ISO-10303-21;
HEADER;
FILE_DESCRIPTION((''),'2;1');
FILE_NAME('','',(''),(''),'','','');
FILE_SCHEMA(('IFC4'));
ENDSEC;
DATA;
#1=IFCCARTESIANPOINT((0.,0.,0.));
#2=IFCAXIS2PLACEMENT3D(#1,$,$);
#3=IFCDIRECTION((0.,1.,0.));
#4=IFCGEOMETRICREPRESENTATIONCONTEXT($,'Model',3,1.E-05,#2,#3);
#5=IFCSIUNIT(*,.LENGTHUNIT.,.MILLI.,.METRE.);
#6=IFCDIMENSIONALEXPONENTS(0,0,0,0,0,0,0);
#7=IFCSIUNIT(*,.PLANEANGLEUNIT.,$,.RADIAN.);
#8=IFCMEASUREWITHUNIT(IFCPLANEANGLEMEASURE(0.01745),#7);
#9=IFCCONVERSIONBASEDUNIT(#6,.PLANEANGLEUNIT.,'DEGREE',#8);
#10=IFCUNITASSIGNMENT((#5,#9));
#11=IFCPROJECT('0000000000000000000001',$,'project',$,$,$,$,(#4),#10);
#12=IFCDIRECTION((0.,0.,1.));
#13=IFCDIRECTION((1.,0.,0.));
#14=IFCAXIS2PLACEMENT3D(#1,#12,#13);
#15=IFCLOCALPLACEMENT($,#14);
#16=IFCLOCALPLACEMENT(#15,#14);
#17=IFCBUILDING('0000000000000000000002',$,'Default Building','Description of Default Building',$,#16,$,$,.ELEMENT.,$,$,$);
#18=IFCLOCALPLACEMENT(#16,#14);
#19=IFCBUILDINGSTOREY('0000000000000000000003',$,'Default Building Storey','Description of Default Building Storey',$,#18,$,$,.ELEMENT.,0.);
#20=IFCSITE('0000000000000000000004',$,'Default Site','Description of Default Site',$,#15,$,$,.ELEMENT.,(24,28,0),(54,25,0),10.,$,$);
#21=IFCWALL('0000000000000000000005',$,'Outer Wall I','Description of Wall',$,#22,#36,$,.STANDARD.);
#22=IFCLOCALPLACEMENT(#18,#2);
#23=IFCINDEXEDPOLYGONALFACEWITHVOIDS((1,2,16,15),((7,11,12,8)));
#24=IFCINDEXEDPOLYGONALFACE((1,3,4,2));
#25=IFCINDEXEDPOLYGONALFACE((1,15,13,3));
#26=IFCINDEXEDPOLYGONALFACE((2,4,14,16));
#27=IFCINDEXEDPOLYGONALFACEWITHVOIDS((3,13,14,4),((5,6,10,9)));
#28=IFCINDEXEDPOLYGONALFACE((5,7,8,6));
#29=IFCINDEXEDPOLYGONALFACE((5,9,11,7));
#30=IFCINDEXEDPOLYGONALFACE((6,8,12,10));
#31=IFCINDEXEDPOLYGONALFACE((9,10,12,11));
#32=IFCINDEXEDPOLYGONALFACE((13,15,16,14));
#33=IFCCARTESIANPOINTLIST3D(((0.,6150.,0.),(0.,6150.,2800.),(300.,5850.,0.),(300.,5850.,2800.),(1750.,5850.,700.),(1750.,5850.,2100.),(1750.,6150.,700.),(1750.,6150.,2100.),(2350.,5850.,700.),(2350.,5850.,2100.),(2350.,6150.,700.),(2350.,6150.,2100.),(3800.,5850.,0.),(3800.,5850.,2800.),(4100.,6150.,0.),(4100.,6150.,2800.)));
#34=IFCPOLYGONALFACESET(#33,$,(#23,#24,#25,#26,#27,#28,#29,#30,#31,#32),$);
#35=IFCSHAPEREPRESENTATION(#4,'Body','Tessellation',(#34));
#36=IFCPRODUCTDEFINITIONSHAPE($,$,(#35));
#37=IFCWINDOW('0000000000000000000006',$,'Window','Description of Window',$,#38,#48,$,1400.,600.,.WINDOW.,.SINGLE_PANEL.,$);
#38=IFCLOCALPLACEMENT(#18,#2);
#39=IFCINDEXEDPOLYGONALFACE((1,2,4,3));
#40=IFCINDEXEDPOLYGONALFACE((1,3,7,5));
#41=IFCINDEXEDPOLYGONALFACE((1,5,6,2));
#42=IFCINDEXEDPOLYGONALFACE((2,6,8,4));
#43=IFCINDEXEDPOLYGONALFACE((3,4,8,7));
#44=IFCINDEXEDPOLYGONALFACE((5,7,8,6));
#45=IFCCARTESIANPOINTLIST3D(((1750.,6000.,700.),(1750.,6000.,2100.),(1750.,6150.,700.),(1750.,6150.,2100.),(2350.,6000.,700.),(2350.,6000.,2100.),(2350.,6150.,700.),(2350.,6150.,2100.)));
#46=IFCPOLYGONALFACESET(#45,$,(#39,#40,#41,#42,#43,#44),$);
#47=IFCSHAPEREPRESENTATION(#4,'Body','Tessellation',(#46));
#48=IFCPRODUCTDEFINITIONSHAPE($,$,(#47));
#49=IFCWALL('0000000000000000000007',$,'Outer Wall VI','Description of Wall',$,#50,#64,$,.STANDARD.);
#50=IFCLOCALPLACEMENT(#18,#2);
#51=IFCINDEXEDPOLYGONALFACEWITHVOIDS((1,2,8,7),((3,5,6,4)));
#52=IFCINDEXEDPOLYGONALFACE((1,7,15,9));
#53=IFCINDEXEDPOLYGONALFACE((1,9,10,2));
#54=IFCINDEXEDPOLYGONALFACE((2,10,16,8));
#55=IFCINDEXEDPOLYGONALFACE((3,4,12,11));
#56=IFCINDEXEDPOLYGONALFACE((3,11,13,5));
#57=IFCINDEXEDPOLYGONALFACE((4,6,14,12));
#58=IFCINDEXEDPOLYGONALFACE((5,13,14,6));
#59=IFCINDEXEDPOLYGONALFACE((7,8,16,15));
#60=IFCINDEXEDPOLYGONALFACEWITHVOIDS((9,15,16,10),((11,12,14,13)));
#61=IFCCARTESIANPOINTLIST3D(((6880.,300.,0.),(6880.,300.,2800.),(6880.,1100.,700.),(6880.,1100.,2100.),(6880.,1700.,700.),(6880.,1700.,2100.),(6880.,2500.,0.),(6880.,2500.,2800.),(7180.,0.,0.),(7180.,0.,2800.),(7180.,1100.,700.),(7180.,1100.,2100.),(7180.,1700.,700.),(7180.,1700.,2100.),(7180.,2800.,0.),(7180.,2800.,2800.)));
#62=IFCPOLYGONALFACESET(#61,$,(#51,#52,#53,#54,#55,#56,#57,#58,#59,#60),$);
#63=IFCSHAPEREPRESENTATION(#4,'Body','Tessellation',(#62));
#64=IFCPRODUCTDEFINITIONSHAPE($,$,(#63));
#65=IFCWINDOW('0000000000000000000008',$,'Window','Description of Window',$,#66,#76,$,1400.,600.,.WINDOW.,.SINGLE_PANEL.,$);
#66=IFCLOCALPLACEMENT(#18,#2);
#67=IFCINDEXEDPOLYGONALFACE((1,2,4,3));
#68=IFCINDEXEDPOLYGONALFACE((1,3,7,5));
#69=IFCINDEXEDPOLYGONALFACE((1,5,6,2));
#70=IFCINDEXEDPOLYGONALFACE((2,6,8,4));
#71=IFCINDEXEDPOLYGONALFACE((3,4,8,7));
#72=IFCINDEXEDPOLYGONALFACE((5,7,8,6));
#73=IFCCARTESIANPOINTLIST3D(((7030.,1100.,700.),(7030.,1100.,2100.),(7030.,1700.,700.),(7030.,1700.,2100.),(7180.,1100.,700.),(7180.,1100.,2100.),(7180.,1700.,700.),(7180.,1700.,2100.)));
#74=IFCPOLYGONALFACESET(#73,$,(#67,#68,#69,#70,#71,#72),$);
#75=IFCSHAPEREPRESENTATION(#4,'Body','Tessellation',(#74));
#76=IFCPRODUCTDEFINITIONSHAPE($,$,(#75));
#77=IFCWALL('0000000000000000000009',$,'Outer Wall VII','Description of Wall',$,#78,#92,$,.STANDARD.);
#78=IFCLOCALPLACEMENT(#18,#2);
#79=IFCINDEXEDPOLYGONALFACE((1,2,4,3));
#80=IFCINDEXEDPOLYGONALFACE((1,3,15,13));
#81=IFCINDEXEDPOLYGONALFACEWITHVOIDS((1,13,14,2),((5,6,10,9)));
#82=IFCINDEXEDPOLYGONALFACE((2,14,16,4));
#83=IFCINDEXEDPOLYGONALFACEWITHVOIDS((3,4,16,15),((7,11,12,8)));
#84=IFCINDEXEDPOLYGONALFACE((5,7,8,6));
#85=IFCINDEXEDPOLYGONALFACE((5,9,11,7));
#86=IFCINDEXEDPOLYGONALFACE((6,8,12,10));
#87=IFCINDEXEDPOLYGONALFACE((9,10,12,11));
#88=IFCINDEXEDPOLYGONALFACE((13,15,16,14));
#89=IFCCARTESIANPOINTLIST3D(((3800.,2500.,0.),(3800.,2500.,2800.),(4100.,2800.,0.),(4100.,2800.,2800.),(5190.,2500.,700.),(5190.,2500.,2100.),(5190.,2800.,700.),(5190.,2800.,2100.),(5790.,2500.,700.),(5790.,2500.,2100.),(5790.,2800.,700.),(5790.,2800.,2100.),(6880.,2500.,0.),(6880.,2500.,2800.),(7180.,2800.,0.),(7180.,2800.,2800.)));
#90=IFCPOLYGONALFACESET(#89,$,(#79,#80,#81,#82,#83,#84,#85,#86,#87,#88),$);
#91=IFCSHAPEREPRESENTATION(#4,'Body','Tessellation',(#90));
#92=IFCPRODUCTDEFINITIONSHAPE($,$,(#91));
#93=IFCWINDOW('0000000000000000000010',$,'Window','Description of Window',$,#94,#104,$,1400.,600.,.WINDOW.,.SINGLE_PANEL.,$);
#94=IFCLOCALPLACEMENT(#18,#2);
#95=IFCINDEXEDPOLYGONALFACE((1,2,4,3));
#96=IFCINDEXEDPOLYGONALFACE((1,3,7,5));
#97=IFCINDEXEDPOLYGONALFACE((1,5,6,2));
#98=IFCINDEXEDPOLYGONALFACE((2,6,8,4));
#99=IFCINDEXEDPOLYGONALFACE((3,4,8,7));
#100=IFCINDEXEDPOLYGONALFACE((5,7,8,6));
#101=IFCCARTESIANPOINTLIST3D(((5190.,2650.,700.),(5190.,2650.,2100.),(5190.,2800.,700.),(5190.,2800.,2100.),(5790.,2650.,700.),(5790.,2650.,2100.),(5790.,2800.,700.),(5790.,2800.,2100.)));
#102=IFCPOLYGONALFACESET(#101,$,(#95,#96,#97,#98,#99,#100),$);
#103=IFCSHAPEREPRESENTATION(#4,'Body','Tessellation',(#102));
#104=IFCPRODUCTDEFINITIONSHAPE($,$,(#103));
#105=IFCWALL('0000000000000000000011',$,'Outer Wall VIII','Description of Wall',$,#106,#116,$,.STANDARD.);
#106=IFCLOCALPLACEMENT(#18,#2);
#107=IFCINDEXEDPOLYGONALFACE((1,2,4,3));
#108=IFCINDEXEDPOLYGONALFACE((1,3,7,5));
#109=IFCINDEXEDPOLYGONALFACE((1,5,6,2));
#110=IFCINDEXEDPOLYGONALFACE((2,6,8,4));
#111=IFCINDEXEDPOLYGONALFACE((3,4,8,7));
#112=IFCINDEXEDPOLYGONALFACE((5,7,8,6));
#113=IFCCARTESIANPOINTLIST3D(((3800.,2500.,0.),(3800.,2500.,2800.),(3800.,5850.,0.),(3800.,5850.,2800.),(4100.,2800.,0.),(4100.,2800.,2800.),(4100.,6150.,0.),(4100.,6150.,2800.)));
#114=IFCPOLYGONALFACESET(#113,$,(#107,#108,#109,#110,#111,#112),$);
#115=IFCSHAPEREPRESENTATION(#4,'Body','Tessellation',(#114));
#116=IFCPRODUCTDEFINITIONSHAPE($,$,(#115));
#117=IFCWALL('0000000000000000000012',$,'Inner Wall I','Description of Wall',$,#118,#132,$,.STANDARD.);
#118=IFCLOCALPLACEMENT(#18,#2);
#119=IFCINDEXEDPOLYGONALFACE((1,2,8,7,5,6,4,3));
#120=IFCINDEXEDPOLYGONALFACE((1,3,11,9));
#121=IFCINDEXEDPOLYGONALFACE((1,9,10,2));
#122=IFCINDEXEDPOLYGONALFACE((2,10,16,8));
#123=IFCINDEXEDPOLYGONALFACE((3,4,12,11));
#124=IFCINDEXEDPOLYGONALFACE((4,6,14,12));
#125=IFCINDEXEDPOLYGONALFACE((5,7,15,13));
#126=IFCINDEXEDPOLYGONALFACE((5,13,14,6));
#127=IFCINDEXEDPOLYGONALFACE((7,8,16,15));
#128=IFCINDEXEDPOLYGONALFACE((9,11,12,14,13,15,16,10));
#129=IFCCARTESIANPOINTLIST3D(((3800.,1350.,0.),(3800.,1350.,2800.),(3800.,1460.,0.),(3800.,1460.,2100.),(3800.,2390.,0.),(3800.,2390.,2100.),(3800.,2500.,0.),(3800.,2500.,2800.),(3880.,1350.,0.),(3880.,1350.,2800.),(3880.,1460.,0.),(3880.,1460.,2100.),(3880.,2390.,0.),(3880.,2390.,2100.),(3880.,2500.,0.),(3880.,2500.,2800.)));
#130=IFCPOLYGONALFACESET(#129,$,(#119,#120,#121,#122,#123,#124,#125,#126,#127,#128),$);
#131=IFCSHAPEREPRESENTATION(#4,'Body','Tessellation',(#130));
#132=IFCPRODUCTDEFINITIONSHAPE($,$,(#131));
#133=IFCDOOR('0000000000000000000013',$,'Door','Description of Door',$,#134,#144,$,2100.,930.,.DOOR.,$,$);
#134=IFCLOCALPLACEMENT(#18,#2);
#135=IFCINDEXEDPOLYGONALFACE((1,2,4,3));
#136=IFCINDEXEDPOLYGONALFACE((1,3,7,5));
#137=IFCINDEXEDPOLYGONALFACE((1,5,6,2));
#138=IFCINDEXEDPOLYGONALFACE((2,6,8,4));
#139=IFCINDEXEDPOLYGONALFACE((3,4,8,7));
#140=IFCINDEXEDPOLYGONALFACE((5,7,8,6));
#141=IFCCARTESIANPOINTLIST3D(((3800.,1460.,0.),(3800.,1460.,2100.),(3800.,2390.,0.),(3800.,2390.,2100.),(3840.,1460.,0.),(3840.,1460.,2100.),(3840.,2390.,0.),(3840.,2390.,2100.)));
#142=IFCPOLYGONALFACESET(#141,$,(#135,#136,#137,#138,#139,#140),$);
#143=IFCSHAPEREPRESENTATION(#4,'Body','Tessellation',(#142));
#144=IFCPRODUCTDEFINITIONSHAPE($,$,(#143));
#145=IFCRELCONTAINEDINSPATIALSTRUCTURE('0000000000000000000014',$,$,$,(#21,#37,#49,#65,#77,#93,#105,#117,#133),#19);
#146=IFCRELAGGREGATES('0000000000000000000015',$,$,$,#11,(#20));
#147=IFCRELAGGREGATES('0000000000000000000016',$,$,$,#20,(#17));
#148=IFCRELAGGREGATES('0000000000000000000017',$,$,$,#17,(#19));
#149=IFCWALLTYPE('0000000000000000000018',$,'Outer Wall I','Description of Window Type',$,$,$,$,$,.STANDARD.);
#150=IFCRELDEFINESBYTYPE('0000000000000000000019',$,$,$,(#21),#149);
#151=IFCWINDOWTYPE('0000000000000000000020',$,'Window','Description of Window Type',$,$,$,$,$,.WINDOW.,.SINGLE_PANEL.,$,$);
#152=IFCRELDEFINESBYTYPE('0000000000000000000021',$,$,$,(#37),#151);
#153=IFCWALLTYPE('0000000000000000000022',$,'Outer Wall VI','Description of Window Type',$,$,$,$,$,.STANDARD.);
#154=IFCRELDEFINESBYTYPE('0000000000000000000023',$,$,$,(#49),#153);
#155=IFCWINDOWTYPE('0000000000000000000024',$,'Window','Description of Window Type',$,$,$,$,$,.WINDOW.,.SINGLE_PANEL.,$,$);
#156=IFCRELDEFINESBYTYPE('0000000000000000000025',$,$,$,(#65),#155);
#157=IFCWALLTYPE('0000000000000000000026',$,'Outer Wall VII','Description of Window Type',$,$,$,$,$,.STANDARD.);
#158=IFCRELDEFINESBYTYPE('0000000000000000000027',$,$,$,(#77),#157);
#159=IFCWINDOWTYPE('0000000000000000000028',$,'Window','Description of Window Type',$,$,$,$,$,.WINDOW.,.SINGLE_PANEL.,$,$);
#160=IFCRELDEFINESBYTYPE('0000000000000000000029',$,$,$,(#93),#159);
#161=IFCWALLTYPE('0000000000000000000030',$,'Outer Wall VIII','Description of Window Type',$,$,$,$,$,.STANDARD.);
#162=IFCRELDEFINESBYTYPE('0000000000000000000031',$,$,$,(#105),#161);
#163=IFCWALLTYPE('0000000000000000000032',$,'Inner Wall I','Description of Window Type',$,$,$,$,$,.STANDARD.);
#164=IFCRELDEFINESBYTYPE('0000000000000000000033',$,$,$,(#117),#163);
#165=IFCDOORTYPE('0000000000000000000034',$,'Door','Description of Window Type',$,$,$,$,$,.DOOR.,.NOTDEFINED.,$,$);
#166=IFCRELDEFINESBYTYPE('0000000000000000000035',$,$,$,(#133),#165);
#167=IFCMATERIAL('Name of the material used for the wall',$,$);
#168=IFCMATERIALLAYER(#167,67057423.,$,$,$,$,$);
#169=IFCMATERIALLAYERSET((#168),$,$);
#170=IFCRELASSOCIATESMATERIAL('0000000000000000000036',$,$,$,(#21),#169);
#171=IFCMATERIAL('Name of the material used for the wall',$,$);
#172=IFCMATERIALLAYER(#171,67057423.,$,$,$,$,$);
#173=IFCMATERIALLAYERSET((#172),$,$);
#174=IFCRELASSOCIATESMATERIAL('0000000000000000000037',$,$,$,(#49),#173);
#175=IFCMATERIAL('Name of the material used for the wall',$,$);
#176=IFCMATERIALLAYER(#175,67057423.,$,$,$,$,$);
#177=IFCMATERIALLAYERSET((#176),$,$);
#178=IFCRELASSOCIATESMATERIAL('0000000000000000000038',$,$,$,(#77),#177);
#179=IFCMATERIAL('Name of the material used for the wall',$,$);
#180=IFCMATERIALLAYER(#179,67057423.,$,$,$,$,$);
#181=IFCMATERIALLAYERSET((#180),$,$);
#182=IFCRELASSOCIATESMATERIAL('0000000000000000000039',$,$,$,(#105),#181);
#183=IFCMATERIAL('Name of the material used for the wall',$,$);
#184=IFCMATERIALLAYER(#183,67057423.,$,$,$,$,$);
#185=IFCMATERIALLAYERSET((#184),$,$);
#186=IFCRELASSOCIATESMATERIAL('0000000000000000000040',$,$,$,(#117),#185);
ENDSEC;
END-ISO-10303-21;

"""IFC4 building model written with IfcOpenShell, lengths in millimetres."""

from ifc_helpers import new_model, entity, si_unit, converted_unit, direction, frame, origin, origin_with_axes, place, context, project, spatial, polyline, outline, extrude, material, layer, layer_set, layer_usage, type_object, element, fill, save


model = new_model("IFC4")

# Units and contexts
model_context = context("Model", 3, precision=1e-05, world=origin(), true_north=direction((0.0, 1.0, 0.0)))
ifc_project = project(units=[si_unit("LENGTHUNIT", "METRE", prefix="MILLI"), converted_unit("PLANEANGLEUNIT", "DEGREE", entity("IfcPlaneAngleMeasure", 0.01745), si_unit("PLANEANGLEUNIT", "RADIAN"), dimensions=[0, 0, 0, 0, 0, 0, 0])], contexts=[model_context])

# Site, building, storey
site_placement = place(None, origin_with_axes())
site = spatial("IfcSite", under=ifc_project, at=site_placement, Name="Default Site", Description="Description of Default Site", CompositionType="ELEMENT", RefLatitude=(24, 28, 0), RefLongitude=(54, 25, 0), RefElevation=10.0)
building_placement = place(site_placement, origin_with_axes())
building = spatial("IfcBuilding", under=site, at=building_placement, Name="Default Building", Description="Description of Default Building", CompositionType="ELEMENT")
storey_placement = place(building_placement, origin_with_axes())
storey = spatial("IfcBuildingStorey", under=building, at=storey_placement, Name="Default Building Storey", Description="Description of Default Building Storey", CompositionType="ELEMENT", Elevation=0.0)

# Walls, openings, windows
ifc_material_1 = material(Name="Name of the material used for the wall")
ifc_layer_1 = layer(ifc_material_1, 67057423.0)
ifc_layer_set_1 = layer_set([ifc_layer_1])
ifc_layer_usage_1 = layer_usage(ifc_layer_set_1, "AXIS2", "POSITIVE", -33528711.5)
wall_type_1 = type_object("IfcWallType", Name="Outer Wall I", Description="Description of Window Type", PredefinedType="STANDARD")
wall_1_placement = place(storey_placement, frame((3950.0, 6000.0, 0.0), z_axis=(0.0, 0.0, 1.0), x_axis=(-1.0, 0.0, 0.0)))
wall_1 = element("IfcWall", 1, at=wall_1_placement, inside=storey, type_object=wall_type_1, material=ifc_layer_usage_1, Name="Outer Wall I", Description="Description of Wall", PredefinedType="STANDARD", context=model_context, shape_type="SweptSolid", body=[
    extrude(outline(polyline([(-150.0, -150.0), (150.0, 150.0), (3650.0, 150.0), (3950.0, -150.0), (-150.0, -150.0)])), origin_with_axes(), (0.0, 0.0, 1.0), 2800.0),
])
opening_1_placement = place(wall_1_placement, frame((1600.0, -150.0, 700.0), z_axis=(0.0, 0.0, 1.0), x_axis=(1.0, 0.0, 0.0)))
opening_1 = element("IfcOpeningElement", 2, at=opening_1_placement, cuts=wall_1, context=model_context, shape_type="SweptSolid", body=[
    extrude(outline(polyline([(0.0, 0.0), (0.0, 300.0), (600.0, 300.0), (600.0, 0.0), (0.0, 0.0)])), origin_with_axes(), (0.0, 0.0, 1.0), 1400.0),
])
window_type_1 = type_object("IfcWindowType", Name="Window", Description="Description of Window Type", PartitioningType="SINGLE_PANEL", PredefinedType="WINDOW")
window_1_placement = place(opening_1_placement, origin_with_axes())
window_1 = element("IfcWindow", 3, at=window_1_placement, inside=storey, type_object=window_type_1, Name="Window", Description="Description of Window", OverallHeight=1400.0, OverallWidth=600.0, PartitioningType="SINGLE_PANEL", PredefinedType="WINDOW", context=model_context, shape_type="SweptSolid", body=[
    extrude(outline(polyline([(0.0, 0.0), (0.0, 150.0), (600.0, 150.0), (600.0, 0.0), (0.0, 0.0)])), origin_with_axes(), (0.0, 0.0, 1.0), 1400.0),
])
fill(opening_1, window_1)
ifc_material_2 = material(Name="Name of the material used for the wall")
ifc_layer_2 = layer(ifc_material_2, 67057423.0)
ifc_layer_set_2 = layer_set([ifc_layer_2])
ifc_layer_usage_2 = layer_usage(ifc_layer_set_2, "AXIS2", "POSITIVE", -33528711.5)
wall_type_2 = type_object("IfcWallType", Name="Outer Wall VI", Description="Description of Window Type", PredefinedType="STANDARD")
wall_2_placement = place(storey_placement, frame((7030.0, 150.0, 0.0), z_axis=(0.0, 0.0, 1.0), x_axis=(0.0, 1.0, 0.0)))
wall_2 = element("IfcWall", 4, at=wall_2_placement, inside=storey, type_object=wall_type_2, material=ifc_layer_usage_2, Name="Outer Wall VI", Description="Description of Wall", PredefinedType="STANDARD", context=model_context, shape_type="SweptSolid", body=[
    extrude(outline(polyline([(-150.0, -150.0), (150.0, 150.0), (2350.0, 150.0), (2650.0, -150.0), (-150.0, -150.0)])), origin_with_axes(), (0.0, 0.0, 1.0), 2800.0),
])
opening_2_placement = place(wall_2_placement, frame((950.0, -150.0, 700.0), z_axis=(0.0, 0.0, 1.0), x_axis=(1.0, 0.0, 0.0)))
opening_2 = element("IfcOpeningElement", 5, at=opening_2_placement, cuts=wall_2, context=model_context, shape_type="SweptSolid", body=[
    extrude(outline(polyline([(0.0, 0.0), (0.0, 300.0), (600.0, 300.0), (600.0, 0.0), (0.0, 0.0)])), origin_with_axes(), (0.0, 0.0, 1.0), 1400.0),
])
window_type_2 = type_object("IfcWindowType", Name="Window", Description="Description of Window Type", PartitioningType="SINGLE_PANEL", PredefinedType="WINDOW")
window_2_placement = place(opening_2_placement, origin_with_axes())
window_2 = element("IfcWindow", 6, at=window_2_placement, inside=storey, type_object=window_type_2, Name="Window", Description="Description of Window", OverallHeight=1400.0, OverallWidth=600.0, PartitioningType="SINGLE_PANEL", PredefinedType="WINDOW", context=model_context, shape_type="SweptSolid", body=[
    extrude(outline(polyline([(0.0, 0.0), (0.0, 150.0), (600.0, 150.0), (600.0, 0.0), (0.0, 0.0)])), origin_with_axes(), (0.0, 0.0, 1.0), 1400.0),
])
fill(opening_2, window_2)
ifc_material_3 = material(Name="Name of the material used for the wall")
ifc_layer_3 = layer(ifc_material_3, 67057423.0)
ifc_layer_set_3 = layer_set([ifc_layer_3])
ifc_layer_usage_3 = layer_usage(ifc_layer_set_3, "AXIS2", "POSITIVE", -33528711.5)
wall_type_3 = type_object("IfcWallType", Name="Outer Wall VII", Description="Description of Window Type", PredefinedType="STANDARD")
wall_3_placement = place(storey_placement, frame((7030.0, 2650.0, 0.0), z_axis=(0.0, 0.0, 1.0), x_axis=(-1.0, 0.0, 0.0)))
wall_3 = element("IfcWall", 7, at=wall_3_placement, inside=storey, type_object=wall_type_3, material=ifc_layer_usage_3, Name="Outer Wall VII", Description="Description of Wall", PredefinedType="STANDARD", context=model_context, shape_type="SweptSolid", body=[
    extrude(outline(polyline([(-150.0, -150.0), (150.0, 150.0), (3230.0, 150.0), (2930.0, -150.0), (-150.0, -150.0)])), origin_with_axes(), (0.0, 0.0, 1.0), 2800.0),
])
opening_3_placement = place(wall_3_placement, frame((1240.0, -150.0, 700.0), z_axis=(0.0, 0.0, 1.0), x_axis=(1.0, 0.0, 0.0)))
opening_3 = element("IfcOpeningElement", 8, at=opening_3_placement, cuts=wall_3, context=model_context, shape_type="SweptSolid", body=[
    extrude(outline(polyline([(0.0, 0.0), (0.0, 300.0), (600.0, 300.0), (600.0, 0.0), (0.0, 0.0)])), origin_with_axes(), (0.0, 0.0, 1.0), 1400.0),
])
window_type_3 = type_object("IfcWindowType", Name="Window", Description="Description of Window Type", PartitioningType="SINGLE_PANEL", PredefinedType="WINDOW")
window_3_placement = place(opening_3_placement, origin_with_axes())
window_3 = element("IfcWindow", 9, at=window_3_placement, inside=storey, type_object=window_type_3, Name="Window", Description="Description of Window", OverallHeight=1400.0, OverallWidth=600.0, PartitioningType="SINGLE_PANEL", PredefinedType="WINDOW", context=model_context, shape_type="SweptSolid", body=[
    extrude(outline(polyline([(0.0, 0.0), (0.0, 150.0), (600.0, 150.0), (600.0, 0.0), (0.0, 0.0)])), origin_with_axes(), (0.0, 0.0, 1.0), 1400.0),
])
fill(opening_3, window_3)

# Wall
ifc_material_4 = material(Name="Name of the material used for the wall")
ifc_layer_4 = layer(ifc_material_4, 67057423.0)
ifc_layer_set_4 = layer_set([ifc_layer_4])
ifc_layer_usage_4 = layer_usage(ifc_layer_set_4, "AXIS2", "POSITIVE", -33528711.5)
wall_type_4 = type_object("IfcWallType", Name="Outer Wall VIII", Description="Description of Window Type", PredefinedType="STANDARD")
wall_4_placement = place(storey_placement, frame((3950.0, 2650.0, 0.0), z_axis=(0.0, 0.0, 1.0), x_axis=(0.0, 1.0, 0.0)))
element("IfcWall", 10, at=wall_4_placement, inside=storey, type_object=wall_type_4, material=ifc_layer_usage_4, Name="Outer Wall VIII", Description="Description of Wall", PredefinedType="STANDARD", context=model_context, shape_type="SweptSolid", body=[
    extrude(outline(polyline([(150.0, -150.0), (-150.0, 150.0), (3200.0, 150.0), (3500.0, -150.0), (150.0, -150.0)])), origin_with_axes(), (0.0, 0.0, 1.0), 2800.0),
])

# Wall, opening, door
ifc_material_5 = material(Name="Name of the material used for the wall")
ifc_layer_5 = layer(ifc_material_5, 67057423.0)
ifc_layer_set_5 = layer_set([ifc_layer_5])
ifc_layer_usage_5 = layer_usage(ifc_layer_set_5, "AXIS2", "POSITIVE", -33528711.5)
wall_type_5 = type_object("IfcWallType", Name="Inner Wall I", Description="Description of Window Type", PredefinedType="STANDARD")
wall_5_placement = place(storey_placement, frame((3840.0, 2500.0, 0.0), z_axis=(0.0, 0.0, 1.0), x_axis=(0.0, -1.0, 0.0)))
wall_5 = element("IfcWall", 11, at=wall_5_placement, inside=storey, type_object=wall_type_5, material=ifc_layer_usage_5, Name="Inner Wall I", Description="Description of Wall", PredefinedType="STANDARD", context=model_context, shape_type="SweptSolid", body=[
    extrude(outline(polyline([(0.0, -40.0), (0.0, 40.0), (1150.0, 40.0), (1150.0, -40.0), (0.0, -40.0)])), origin_with_axes(), (0.0, 0.0, 1.0), 2800.0),
])
opening_4_placement = place(wall_5_placement, frame((110.0, -40.0, 0.0), z_axis=(0.0, 0.0, 1.0), x_axis=(1.0, 0.0, 0.0)))
opening_4 = element("IfcOpeningElement", 12, at=opening_4_placement, cuts=wall_5, context=model_context, shape_type="SweptSolid", body=[
    extrude(outline(polyline([(0.0, 0.0), (0.0, 80.0), (930.0, 80.0), (930.0, 0.0), (0.0, 0.0)])), origin_with_axes(), (0.0, 0.0, 1.0), 2100.0),
])
door_type_1 = type_object("IfcDoorType", Name="Door", Description="Description of Window Type", PredefinedType="DOOR")
door_1_placement = place(opening_4_placement, origin_with_axes())
door_1 = element("IfcDoor", 13, at=door_1_placement, inside=storey, type_object=door_type_1, Name="Door", Description="Description of Door", OverallHeight=2100.0, OverallWidth=930.0, PredefinedType="DOOR", context=model_context, shape_type="SweptSolid", body=[
    extrude(outline(polyline([(0.0, 0.0), (0.0, 40.0), (930.0, 40.0), (930.0, 0.0), (0.0, 0.0)])), origin_with_axes(), (0.0, 0.0, 1.0), 2100.0),
])
fill(opening_4, door_1)

save(model, "model.ifc")
